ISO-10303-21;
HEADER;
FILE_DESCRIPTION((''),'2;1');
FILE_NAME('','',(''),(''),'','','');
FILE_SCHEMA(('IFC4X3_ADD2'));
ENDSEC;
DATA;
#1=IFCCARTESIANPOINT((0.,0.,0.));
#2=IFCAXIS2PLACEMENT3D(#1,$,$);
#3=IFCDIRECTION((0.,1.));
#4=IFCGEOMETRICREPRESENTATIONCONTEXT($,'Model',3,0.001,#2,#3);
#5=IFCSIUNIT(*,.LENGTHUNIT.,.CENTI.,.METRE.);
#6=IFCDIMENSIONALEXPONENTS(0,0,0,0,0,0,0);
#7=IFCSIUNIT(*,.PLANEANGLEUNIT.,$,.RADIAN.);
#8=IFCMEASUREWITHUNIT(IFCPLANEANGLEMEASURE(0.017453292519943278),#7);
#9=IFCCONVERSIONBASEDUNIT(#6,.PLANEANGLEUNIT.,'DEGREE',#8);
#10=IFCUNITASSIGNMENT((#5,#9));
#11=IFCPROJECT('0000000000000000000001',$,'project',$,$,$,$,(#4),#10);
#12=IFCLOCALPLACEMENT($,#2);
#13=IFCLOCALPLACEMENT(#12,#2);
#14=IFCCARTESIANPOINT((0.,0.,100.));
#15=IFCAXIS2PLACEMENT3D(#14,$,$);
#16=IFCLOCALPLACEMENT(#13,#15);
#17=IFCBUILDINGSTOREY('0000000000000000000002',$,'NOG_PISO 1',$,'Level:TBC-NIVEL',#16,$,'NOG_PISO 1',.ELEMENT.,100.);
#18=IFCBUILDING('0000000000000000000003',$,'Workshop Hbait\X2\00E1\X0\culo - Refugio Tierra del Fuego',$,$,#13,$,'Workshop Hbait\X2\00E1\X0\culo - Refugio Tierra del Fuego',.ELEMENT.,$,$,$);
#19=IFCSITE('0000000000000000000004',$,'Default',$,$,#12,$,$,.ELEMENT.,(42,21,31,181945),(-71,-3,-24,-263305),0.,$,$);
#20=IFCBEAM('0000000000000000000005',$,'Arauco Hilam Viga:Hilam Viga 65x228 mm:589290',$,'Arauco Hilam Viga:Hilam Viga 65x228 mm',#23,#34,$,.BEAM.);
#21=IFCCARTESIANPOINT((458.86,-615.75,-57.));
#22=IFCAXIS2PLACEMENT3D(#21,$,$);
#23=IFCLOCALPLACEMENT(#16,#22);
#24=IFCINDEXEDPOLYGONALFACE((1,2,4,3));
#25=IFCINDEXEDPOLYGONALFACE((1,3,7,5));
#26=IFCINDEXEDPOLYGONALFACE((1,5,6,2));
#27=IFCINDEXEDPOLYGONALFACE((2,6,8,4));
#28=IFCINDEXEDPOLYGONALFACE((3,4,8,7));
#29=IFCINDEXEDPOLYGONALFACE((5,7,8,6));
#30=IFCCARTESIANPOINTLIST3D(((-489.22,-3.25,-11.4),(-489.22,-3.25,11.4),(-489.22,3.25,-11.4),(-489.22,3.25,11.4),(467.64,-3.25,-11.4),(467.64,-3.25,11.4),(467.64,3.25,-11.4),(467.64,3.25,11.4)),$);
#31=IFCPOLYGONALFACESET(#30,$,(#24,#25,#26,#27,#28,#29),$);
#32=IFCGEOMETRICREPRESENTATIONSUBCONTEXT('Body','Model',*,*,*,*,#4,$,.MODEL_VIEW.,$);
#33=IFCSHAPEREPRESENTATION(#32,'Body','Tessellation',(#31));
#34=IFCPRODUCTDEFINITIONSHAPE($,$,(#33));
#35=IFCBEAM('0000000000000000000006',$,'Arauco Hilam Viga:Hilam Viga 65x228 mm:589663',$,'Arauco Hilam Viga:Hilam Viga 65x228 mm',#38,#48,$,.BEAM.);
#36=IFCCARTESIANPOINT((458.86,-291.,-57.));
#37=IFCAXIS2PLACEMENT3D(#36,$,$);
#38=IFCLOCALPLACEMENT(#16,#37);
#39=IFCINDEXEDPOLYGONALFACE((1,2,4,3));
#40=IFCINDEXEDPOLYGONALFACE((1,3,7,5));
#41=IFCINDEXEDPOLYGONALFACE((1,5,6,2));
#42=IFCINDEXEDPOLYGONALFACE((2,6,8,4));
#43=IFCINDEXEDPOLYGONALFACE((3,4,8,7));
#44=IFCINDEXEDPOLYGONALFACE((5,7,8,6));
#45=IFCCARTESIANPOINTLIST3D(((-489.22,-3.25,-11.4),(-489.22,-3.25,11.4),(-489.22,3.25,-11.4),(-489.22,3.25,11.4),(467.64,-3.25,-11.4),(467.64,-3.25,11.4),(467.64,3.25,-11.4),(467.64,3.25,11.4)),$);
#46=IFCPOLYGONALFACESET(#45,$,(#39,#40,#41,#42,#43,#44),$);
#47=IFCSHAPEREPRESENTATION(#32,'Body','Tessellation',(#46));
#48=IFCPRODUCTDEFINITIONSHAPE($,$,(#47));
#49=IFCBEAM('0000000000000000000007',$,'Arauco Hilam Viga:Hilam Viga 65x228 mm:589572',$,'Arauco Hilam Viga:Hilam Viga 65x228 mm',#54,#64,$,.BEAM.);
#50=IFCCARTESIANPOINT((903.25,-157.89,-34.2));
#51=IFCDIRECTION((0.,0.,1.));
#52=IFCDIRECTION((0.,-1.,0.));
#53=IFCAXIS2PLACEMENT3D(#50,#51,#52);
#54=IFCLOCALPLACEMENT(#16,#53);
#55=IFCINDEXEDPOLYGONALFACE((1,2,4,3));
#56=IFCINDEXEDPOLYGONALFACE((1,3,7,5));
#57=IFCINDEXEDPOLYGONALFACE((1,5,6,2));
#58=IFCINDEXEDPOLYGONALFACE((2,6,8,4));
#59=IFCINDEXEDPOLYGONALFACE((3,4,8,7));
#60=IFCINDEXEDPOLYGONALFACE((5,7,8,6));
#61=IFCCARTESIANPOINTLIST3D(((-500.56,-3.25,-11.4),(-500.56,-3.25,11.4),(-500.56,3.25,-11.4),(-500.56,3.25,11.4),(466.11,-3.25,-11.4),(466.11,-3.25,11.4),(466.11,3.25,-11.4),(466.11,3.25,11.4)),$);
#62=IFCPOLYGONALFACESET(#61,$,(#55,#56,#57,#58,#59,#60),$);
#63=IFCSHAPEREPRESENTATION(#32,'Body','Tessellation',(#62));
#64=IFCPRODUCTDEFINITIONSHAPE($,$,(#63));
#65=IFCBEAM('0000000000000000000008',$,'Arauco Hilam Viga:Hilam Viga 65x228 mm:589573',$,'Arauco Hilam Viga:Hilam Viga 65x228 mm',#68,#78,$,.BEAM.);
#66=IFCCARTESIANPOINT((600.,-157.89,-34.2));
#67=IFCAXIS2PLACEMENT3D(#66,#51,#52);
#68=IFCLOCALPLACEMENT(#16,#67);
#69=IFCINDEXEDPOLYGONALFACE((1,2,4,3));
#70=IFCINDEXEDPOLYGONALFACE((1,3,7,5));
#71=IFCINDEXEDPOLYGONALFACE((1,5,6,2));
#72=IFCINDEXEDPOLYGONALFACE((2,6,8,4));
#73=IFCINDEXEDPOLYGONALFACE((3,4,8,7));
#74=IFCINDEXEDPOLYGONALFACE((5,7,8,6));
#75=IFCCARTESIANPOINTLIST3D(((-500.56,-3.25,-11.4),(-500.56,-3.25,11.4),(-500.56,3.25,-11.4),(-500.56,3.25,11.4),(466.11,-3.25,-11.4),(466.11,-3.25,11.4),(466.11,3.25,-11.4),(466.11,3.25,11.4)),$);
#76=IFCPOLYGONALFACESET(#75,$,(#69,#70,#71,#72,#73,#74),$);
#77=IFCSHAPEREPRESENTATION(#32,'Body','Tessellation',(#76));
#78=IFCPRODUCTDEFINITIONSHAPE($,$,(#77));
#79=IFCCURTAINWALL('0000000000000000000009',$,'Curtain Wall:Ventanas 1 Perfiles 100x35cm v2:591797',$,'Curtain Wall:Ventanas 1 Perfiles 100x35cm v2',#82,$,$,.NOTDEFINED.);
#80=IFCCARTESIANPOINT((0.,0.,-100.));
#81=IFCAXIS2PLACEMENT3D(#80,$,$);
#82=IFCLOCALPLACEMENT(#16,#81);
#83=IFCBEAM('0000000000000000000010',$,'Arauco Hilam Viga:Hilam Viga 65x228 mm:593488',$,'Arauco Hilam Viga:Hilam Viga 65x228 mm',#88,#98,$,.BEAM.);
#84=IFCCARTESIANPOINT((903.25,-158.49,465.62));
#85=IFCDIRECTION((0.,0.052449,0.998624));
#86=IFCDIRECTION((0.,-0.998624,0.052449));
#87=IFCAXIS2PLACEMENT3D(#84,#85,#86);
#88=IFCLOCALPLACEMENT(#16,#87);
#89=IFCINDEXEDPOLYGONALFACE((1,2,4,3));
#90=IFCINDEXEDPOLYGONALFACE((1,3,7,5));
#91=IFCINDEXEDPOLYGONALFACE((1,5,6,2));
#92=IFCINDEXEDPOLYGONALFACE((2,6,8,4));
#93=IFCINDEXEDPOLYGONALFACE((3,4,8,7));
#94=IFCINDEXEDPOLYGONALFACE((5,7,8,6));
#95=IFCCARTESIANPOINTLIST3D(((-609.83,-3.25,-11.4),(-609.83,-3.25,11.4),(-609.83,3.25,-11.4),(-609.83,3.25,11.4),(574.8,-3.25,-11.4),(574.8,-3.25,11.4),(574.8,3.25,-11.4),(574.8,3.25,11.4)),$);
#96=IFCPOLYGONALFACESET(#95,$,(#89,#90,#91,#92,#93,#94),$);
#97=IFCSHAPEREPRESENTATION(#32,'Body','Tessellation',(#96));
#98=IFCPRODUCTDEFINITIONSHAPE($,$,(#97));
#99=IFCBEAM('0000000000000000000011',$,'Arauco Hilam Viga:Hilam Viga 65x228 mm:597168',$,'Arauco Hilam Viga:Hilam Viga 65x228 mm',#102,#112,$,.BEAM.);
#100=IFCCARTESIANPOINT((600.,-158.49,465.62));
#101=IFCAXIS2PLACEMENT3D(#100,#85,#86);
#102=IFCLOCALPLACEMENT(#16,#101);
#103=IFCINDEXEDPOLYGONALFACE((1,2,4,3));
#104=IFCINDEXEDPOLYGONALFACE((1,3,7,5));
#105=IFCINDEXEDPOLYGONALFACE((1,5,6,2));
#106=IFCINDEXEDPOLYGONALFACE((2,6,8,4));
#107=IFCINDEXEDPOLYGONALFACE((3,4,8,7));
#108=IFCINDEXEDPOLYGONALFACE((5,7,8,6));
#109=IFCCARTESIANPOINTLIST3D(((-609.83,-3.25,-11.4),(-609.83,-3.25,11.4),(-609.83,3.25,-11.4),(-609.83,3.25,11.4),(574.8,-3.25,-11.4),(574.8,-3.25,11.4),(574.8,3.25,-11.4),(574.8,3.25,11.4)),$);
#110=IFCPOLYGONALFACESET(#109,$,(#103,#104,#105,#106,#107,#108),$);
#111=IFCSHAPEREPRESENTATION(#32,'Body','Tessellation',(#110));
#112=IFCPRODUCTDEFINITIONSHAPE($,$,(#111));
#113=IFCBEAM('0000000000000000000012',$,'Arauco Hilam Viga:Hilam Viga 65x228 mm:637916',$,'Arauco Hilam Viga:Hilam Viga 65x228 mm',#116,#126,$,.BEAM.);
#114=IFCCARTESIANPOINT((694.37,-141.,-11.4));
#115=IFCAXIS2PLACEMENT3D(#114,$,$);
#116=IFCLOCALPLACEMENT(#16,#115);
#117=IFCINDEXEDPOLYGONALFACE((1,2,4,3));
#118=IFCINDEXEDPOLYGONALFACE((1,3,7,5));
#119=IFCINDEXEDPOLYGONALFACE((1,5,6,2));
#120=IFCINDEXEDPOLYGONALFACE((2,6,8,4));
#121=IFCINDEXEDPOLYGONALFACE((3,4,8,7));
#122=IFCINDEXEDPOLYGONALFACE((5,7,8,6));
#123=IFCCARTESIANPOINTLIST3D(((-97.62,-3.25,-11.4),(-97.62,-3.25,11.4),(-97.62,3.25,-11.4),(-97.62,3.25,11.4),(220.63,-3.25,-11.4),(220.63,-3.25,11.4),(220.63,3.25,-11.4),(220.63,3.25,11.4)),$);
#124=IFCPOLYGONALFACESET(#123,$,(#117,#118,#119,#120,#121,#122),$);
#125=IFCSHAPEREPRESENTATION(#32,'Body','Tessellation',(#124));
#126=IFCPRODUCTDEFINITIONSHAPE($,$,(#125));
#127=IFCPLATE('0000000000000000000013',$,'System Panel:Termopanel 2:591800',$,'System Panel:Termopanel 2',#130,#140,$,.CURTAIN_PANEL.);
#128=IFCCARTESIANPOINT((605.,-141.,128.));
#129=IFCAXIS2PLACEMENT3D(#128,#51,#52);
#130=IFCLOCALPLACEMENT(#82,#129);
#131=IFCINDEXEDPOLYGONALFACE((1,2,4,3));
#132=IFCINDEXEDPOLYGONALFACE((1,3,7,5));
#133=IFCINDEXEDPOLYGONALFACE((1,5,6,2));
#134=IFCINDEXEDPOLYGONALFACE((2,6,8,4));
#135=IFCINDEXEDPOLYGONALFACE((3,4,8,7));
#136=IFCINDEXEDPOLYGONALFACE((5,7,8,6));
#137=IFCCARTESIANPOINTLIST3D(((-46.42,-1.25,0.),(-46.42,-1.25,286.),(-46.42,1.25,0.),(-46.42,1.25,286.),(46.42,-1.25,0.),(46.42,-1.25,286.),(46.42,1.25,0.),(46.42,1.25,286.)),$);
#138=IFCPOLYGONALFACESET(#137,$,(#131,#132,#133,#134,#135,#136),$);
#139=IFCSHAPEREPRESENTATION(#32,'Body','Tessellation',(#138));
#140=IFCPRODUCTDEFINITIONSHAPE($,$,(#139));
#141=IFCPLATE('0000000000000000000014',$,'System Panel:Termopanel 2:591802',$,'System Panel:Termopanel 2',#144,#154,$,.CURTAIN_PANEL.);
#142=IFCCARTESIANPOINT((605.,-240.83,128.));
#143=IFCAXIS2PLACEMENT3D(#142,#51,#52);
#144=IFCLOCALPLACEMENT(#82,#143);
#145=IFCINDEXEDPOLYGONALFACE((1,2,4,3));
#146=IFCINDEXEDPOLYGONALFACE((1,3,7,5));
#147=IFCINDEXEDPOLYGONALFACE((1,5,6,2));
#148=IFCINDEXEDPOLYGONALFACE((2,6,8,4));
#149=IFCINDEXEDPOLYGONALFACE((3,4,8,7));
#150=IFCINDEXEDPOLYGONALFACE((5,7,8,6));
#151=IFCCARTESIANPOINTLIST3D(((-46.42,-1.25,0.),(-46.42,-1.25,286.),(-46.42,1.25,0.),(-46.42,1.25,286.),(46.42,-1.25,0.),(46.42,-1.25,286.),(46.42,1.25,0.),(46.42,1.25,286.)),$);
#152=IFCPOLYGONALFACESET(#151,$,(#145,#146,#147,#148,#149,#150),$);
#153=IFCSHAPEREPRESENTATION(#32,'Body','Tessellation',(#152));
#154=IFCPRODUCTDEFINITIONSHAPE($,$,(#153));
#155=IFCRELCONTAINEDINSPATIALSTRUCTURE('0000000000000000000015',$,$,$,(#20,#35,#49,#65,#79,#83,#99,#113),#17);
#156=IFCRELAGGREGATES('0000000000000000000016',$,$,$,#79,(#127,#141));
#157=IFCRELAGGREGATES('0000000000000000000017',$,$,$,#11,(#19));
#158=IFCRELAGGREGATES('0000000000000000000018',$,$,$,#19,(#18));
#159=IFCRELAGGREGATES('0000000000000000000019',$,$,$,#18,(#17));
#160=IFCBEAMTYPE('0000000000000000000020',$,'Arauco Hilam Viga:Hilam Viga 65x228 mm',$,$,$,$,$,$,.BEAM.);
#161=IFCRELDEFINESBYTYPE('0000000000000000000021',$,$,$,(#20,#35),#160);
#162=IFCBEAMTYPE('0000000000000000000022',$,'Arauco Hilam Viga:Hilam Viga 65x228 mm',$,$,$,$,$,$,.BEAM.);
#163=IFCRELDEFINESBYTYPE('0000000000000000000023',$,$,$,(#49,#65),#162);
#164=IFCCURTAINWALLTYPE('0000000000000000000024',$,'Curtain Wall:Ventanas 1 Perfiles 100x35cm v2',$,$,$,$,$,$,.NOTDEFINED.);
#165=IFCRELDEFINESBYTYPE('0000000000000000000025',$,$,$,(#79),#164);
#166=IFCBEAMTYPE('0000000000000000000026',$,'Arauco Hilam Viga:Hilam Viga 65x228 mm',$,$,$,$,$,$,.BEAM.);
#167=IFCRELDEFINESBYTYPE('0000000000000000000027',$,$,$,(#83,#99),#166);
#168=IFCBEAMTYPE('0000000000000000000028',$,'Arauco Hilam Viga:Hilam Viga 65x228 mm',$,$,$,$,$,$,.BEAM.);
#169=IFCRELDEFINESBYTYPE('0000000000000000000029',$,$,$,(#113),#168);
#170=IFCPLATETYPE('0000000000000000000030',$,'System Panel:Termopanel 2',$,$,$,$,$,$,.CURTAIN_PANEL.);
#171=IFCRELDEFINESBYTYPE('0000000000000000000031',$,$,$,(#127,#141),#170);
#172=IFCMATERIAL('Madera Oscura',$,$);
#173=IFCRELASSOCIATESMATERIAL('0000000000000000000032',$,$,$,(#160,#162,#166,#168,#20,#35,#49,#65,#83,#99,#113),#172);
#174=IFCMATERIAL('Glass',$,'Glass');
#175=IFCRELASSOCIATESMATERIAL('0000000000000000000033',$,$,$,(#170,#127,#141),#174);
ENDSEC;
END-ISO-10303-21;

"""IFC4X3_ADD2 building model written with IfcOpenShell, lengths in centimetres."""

from ifc_helpers import new_model, entity, si_unit, converted_unit, direction, frame, origin, origin_2d_with_axis, place, context, subcontext, project, spatial, rectangle, extrude, source, transform, mapped, material, material_profile, profile_set, profile_usage, type_object, type_shapes, element, aggregate, save


model = new_model("IFC4X3_ADD2")

# Units and contexts
model_context = context("Model", 3, precision=0.001, world=origin(), true_north=direction((0.0, 1.0)))
body_context = subcontext(model_context, "Body", "Model", "MODEL_VIEW")
ifc_project = project(units=[si_unit("LENGTHUNIT", "METRE", prefix="CENTI"), converted_unit("PLANEANGLEUNIT", "DEGREE", entity("IfcPlaneAngleMeasure", 0.017453292519943278), si_unit("PLANEANGLEUNIT", "RADIAN"), dimensions=[0, 0, 0, 0, 0, 0, 0])], contexts=[model_context])

# Site, building, storey
site_placement = place(None, origin())
site = spatial("IfcSite", under=ifc_project, at=site_placement, Name="Default", CompositionType="ELEMENT", RefLatitude=(42, 21, 31, 181945), RefLongitude=(-71, -3, -24, -263305), RefElevation=0.0)
building_placement = place(site_placement, origin())
building = spatial("IfcBuilding", under=site, at=building_placement, Name="Workshop Hbaitáculo - Refugio Tierra del Fuego", LongName="Workshop Hbaitáculo - Refugio Tierra del Fuego", CompositionType="ELEMENT")
storey_placement = place(building_placement, frame((0.0, 0.0, 100.0)))
storey = spatial("IfcBuildingStorey", under=building, at=storey_placement, Name="NOG_PISO 1", ObjectType="Level:TBC-NIVEL", LongName="NOG_PISO 1", CompositionType="ELEMENT", Elevation=100.0)

# Beams
ifc_material_1 = material(Name="Madera Oscura")
ifc_material_profile_1 = material_profile(ifc_material_1, rectangle(XDim=930.0, YDim=6.5, at=origin_2d_with_axis()), Name="Hilam Viga 65x228 mm")
ifc_profile_set_1 = profile_set([ifc_material_profile_1], Name="Hilam Viga 65x228 mm")
ifc_profile_usage_1 = profile_usage(ifc_profile_set_1, cardinal=8)
beam_type_1 = type_object("IfcBeamType", Name="Arauco Hilam Viga:Hilam Viga 65x228 mm", PredefinedType="BEAM", material=ifc_profile_set_1)
shared_shape_1 = source(origin(), body_context, "Body", "SweptSolid", [
    extrude(rectangle(XDim=6.5, YDim=956.86, at=origin_2d_with_axis()), frame((-10.79, 0.0, -11.4), z_axis=(0.0, 0.0, 1.0), x_axis=(0.0, 1.0, 0.0)), (0.0, 0.0, 1.0), 22.8),
])
type_shapes(beam_type_1, [shared_shape_1])
for number, where, name in (
    (1, (458.86, -615.75, -57.0), "Arauco Hilam Viga:Hilam Viga 65x228 mm:589290"),
    (2, (458.86, -291.0, -57.0), "Arauco Hilam Viga:Hilam Viga 65x228 mm:589663"),
):
    element("IfcBeam", number, at=place(storey_placement, frame(where)), inside=storey, type_object=beam_type_1, material=ifc_profile_usage_1, Name=name, ObjectType="Arauco Hilam Viga:Hilam Viga 65x228 mm", PredefinedType="BEAM", context=body_context, shape_type="MappedRepresentation", body=[
        mapped(shared_shape_1, transform((0.0, 0.0, 0.0), scale=1.0)),
    ])
beam_type_2 = type_object("IfcBeamType", Name="Arauco Hilam Viga:Hilam Viga 65x228 mm", PredefinedType="BEAM", material=ifc_profile_set_1)
shared_shape_2 = source(origin(), body_context, "Body", "SweptSolid", [
    extrude(rectangle(XDim=6.5, YDim=966.67, at=origin_2d_with_axis()), frame((-17.23, 0.0, -11.4), z_axis=(0.0, 0.0, 1.0), x_axis=(0.0, 1.0, 0.0)), (0.0, 0.0, 1.0), 22.8),
])
type_shapes(beam_type_2, [shared_shape_2])
for number, where, z_axis, x_axis, name in (
    (3, (903.25, -157.89, -34.2), (0.0, 0.0, 1.0), (0.0, -1.0, 0.0), "Arauco Hilam Viga:Hilam Viga 65x228 mm:589572"),
    (4, (600.0, -157.89, -34.2), (0.0, 0.0, 1.0), (0.0, -1.0, 0.0), "Arauco Hilam Viga:Hilam Viga 65x228 mm:589573"),
):
    element("IfcBeam", number, at=place(storey_placement, frame(where, z_axis=z_axis, x_axis=x_axis)), inside=storey, type_object=beam_type_2, material=ifc_profile_usage_1, Name=name, ObjectType="Arauco Hilam Viga:Hilam Viga 65x228 mm", PredefinedType="BEAM", context=body_context, shape_type="MappedRepresentation", body=[
        mapped(shared_shape_2, transform((0.0, 0.0, 0.0), scale=1.0)),
    ])

# Curtain wall
curtain_wall_type = type_object("IfcCurtainWallType", Name="Curtain Wall:Ventanas 1 Perfiles 100x35cm v2", PredefinedType="NOTDEFINED")
curtain_wall_placement = place(storey_placement, frame((0.0, 0.0, -100.0)))
curtain_wall = element("IfcCurtainWall", 5, at=curtain_wall_placement, inside=storey, type_object=curtain_wall_type, Name="Curtain Wall:Ventanas 1 Perfiles 100x35cm v2:591797", ObjectType="Curtain Wall:Ventanas 1 Perfiles 100x35cm v2", PredefinedType="NOTDEFINED")

# Beams
beam_type_3 = type_object("IfcBeamType", Name="Arauco Hilam Viga:Hilam Viga 65x228 mm", PredefinedType="BEAM", material=ifc_profile_set_1)
shared_shape_3 = source(origin(), body_context, "Body", "SweptSolid", [
    extrude(rectangle(XDim=6.5, YDim=1184.63, at=origin_2d_with_axis()), frame((-17.52, 0.0, -11.4), z_axis=(0.0, 0.0, 1.0), x_axis=(0.0, 1.0, 0.0)), (0.0, 0.0, 1.0), 22.8),
])
type_shapes(beam_type_3, [shared_shape_3])
for number, where, z_axis, x_axis, name in (
    (6, (903.25, -158.49, 465.62), (0.0, 0.052449, 0.998624), (0.0, -0.998624, 0.052449), "Arauco Hilam Viga:Hilam Viga 65x228 mm:593488"),
    (7, (600.0, -158.49, 465.62), (0.0, 0.052449, 0.998624), (0.0, -0.998624, 0.052449), "Arauco Hilam Viga:Hilam Viga 65x228 mm:597168"),
):
    element("IfcBeam", number, at=place(storey_placement, frame(where, z_axis=z_axis, x_axis=x_axis)), inside=storey, type_object=beam_type_3, material=ifc_profile_usage_1, Name=name, ObjectType="Arauco Hilam Viga:Hilam Viga 65x228 mm", PredefinedType="BEAM", context=body_context, shape_type="MappedRepresentation", body=[
        mapped(shared_shape_3, transform((0.0, 0.0, 0.0), scale=1.0)),
    ])
beam_type_4 = type_object("IfcBeamType", Name="Arauco Hilam Viga:Hilam Viga 65x228 mm", PredefinedType="BEAM", material=ifc_profile_set_1)
shared_shape_4 = source(origin(), body_context, "Body", "SweptSolid", [
    extrude(rectangle(XDim=318.25, YDim=6.5, at=origin_2d_with_axis()), frame((61.5, 0.0, -11.4), z_axis=(0.0, 0.0, 1.0), x_axis=(-1.0, 0.0, 0.0)), (0.0, 0.0, 1.0), 22.8),
])
type_shapes(beam_type_4, [shared_shape_4])
beam_1_placement = place(storey_placement, frame((694.37, -141.0, -11.4)))
element("IfcBeam", 8, at=beam_1_placement, inside=storey, type_object=beam_type_4, material=ifc_profile_usage_1, Name="Arauco Hilam Viga:Hilam Viga 65x228 mm:637916", ObjectType="Arauco Hilam Viga:Hilam Viga 65x228 mm", PredefinedType="BEAM", context=body_context, shape_type="MappedRepresentation", body=[
    mapped(shared_shape_4, transform((0.0, 0.0, 0.0), scale=1.0)),
])

# Plates
ifc_material_2 = material(Name="Glass", Category="Glass")
plate_type = type_object("IfcPlateType", Name="System Panel:Termopanel 2", PredefinedType="CURTAIN_PANEL", material=ifc_material_2)
shared_shape_5 = source(origin(), body_context, "Body", "SweptSolid", [
    extrude(rectangle(XDim=2.5, YDim=92.83, at=origin_2d_with_axis()), frame((0.0, 0.0, 0.0), z_axis=(0.0, 0.0, 1.0), x_axis=(0.0, 1.0, 0.0)), (0.0, 0.0, 1.0), 286.0),
])
type_shapes(plate_type, [shared_shape_5])
plate_1_placement = place(curtain_wall_placement, frame((605.0, -141.0, 128.0), z_axis=(0.0, 0.0, 1.0), x_axis=(0.0, -1.0, 0.0)))
plate_1 = element("IfcPlate", 9, at=plate_1_placement, type_object=plate_type, material=ifc_material_2, Name="System Panel:Termopanel 2:591800", ObjectType="System Panel:Termopanel 2", PredefinedType="CURTAIN_PANEL", context=body_context, shape_type="MappedRepresentation", body=[
    mapped(shared_shape_5, transform((0.0, 0.0, 0.0), scale=1.0)),
])
plate_2_placement = place(curtain_wall_placement, frame((605.0, -240.83, 128.0), z_axis=(0.0, 0.0, 1.0), x_axis=(0.0, -1.0, 0.0)))
plate_2 = element("IfcPlate", 10, at=plate_2_placement, type_object=plate_type, material=ifc_material_2, Name="System Panel:Termopanel 2:591802", ObjectType="System Panel:Termopanel 2", PredefinedType="CURTAIN_PANEL", context=body_context, shape_type="MappedRepresentation", body=[
    mapped(shared_shape_5, transform((0.0, 0.0, 0.0), scale=1.0)),
])
aggregate(curtain_wall, [plate_1, plate_2])

save(model, "model.ifc")
